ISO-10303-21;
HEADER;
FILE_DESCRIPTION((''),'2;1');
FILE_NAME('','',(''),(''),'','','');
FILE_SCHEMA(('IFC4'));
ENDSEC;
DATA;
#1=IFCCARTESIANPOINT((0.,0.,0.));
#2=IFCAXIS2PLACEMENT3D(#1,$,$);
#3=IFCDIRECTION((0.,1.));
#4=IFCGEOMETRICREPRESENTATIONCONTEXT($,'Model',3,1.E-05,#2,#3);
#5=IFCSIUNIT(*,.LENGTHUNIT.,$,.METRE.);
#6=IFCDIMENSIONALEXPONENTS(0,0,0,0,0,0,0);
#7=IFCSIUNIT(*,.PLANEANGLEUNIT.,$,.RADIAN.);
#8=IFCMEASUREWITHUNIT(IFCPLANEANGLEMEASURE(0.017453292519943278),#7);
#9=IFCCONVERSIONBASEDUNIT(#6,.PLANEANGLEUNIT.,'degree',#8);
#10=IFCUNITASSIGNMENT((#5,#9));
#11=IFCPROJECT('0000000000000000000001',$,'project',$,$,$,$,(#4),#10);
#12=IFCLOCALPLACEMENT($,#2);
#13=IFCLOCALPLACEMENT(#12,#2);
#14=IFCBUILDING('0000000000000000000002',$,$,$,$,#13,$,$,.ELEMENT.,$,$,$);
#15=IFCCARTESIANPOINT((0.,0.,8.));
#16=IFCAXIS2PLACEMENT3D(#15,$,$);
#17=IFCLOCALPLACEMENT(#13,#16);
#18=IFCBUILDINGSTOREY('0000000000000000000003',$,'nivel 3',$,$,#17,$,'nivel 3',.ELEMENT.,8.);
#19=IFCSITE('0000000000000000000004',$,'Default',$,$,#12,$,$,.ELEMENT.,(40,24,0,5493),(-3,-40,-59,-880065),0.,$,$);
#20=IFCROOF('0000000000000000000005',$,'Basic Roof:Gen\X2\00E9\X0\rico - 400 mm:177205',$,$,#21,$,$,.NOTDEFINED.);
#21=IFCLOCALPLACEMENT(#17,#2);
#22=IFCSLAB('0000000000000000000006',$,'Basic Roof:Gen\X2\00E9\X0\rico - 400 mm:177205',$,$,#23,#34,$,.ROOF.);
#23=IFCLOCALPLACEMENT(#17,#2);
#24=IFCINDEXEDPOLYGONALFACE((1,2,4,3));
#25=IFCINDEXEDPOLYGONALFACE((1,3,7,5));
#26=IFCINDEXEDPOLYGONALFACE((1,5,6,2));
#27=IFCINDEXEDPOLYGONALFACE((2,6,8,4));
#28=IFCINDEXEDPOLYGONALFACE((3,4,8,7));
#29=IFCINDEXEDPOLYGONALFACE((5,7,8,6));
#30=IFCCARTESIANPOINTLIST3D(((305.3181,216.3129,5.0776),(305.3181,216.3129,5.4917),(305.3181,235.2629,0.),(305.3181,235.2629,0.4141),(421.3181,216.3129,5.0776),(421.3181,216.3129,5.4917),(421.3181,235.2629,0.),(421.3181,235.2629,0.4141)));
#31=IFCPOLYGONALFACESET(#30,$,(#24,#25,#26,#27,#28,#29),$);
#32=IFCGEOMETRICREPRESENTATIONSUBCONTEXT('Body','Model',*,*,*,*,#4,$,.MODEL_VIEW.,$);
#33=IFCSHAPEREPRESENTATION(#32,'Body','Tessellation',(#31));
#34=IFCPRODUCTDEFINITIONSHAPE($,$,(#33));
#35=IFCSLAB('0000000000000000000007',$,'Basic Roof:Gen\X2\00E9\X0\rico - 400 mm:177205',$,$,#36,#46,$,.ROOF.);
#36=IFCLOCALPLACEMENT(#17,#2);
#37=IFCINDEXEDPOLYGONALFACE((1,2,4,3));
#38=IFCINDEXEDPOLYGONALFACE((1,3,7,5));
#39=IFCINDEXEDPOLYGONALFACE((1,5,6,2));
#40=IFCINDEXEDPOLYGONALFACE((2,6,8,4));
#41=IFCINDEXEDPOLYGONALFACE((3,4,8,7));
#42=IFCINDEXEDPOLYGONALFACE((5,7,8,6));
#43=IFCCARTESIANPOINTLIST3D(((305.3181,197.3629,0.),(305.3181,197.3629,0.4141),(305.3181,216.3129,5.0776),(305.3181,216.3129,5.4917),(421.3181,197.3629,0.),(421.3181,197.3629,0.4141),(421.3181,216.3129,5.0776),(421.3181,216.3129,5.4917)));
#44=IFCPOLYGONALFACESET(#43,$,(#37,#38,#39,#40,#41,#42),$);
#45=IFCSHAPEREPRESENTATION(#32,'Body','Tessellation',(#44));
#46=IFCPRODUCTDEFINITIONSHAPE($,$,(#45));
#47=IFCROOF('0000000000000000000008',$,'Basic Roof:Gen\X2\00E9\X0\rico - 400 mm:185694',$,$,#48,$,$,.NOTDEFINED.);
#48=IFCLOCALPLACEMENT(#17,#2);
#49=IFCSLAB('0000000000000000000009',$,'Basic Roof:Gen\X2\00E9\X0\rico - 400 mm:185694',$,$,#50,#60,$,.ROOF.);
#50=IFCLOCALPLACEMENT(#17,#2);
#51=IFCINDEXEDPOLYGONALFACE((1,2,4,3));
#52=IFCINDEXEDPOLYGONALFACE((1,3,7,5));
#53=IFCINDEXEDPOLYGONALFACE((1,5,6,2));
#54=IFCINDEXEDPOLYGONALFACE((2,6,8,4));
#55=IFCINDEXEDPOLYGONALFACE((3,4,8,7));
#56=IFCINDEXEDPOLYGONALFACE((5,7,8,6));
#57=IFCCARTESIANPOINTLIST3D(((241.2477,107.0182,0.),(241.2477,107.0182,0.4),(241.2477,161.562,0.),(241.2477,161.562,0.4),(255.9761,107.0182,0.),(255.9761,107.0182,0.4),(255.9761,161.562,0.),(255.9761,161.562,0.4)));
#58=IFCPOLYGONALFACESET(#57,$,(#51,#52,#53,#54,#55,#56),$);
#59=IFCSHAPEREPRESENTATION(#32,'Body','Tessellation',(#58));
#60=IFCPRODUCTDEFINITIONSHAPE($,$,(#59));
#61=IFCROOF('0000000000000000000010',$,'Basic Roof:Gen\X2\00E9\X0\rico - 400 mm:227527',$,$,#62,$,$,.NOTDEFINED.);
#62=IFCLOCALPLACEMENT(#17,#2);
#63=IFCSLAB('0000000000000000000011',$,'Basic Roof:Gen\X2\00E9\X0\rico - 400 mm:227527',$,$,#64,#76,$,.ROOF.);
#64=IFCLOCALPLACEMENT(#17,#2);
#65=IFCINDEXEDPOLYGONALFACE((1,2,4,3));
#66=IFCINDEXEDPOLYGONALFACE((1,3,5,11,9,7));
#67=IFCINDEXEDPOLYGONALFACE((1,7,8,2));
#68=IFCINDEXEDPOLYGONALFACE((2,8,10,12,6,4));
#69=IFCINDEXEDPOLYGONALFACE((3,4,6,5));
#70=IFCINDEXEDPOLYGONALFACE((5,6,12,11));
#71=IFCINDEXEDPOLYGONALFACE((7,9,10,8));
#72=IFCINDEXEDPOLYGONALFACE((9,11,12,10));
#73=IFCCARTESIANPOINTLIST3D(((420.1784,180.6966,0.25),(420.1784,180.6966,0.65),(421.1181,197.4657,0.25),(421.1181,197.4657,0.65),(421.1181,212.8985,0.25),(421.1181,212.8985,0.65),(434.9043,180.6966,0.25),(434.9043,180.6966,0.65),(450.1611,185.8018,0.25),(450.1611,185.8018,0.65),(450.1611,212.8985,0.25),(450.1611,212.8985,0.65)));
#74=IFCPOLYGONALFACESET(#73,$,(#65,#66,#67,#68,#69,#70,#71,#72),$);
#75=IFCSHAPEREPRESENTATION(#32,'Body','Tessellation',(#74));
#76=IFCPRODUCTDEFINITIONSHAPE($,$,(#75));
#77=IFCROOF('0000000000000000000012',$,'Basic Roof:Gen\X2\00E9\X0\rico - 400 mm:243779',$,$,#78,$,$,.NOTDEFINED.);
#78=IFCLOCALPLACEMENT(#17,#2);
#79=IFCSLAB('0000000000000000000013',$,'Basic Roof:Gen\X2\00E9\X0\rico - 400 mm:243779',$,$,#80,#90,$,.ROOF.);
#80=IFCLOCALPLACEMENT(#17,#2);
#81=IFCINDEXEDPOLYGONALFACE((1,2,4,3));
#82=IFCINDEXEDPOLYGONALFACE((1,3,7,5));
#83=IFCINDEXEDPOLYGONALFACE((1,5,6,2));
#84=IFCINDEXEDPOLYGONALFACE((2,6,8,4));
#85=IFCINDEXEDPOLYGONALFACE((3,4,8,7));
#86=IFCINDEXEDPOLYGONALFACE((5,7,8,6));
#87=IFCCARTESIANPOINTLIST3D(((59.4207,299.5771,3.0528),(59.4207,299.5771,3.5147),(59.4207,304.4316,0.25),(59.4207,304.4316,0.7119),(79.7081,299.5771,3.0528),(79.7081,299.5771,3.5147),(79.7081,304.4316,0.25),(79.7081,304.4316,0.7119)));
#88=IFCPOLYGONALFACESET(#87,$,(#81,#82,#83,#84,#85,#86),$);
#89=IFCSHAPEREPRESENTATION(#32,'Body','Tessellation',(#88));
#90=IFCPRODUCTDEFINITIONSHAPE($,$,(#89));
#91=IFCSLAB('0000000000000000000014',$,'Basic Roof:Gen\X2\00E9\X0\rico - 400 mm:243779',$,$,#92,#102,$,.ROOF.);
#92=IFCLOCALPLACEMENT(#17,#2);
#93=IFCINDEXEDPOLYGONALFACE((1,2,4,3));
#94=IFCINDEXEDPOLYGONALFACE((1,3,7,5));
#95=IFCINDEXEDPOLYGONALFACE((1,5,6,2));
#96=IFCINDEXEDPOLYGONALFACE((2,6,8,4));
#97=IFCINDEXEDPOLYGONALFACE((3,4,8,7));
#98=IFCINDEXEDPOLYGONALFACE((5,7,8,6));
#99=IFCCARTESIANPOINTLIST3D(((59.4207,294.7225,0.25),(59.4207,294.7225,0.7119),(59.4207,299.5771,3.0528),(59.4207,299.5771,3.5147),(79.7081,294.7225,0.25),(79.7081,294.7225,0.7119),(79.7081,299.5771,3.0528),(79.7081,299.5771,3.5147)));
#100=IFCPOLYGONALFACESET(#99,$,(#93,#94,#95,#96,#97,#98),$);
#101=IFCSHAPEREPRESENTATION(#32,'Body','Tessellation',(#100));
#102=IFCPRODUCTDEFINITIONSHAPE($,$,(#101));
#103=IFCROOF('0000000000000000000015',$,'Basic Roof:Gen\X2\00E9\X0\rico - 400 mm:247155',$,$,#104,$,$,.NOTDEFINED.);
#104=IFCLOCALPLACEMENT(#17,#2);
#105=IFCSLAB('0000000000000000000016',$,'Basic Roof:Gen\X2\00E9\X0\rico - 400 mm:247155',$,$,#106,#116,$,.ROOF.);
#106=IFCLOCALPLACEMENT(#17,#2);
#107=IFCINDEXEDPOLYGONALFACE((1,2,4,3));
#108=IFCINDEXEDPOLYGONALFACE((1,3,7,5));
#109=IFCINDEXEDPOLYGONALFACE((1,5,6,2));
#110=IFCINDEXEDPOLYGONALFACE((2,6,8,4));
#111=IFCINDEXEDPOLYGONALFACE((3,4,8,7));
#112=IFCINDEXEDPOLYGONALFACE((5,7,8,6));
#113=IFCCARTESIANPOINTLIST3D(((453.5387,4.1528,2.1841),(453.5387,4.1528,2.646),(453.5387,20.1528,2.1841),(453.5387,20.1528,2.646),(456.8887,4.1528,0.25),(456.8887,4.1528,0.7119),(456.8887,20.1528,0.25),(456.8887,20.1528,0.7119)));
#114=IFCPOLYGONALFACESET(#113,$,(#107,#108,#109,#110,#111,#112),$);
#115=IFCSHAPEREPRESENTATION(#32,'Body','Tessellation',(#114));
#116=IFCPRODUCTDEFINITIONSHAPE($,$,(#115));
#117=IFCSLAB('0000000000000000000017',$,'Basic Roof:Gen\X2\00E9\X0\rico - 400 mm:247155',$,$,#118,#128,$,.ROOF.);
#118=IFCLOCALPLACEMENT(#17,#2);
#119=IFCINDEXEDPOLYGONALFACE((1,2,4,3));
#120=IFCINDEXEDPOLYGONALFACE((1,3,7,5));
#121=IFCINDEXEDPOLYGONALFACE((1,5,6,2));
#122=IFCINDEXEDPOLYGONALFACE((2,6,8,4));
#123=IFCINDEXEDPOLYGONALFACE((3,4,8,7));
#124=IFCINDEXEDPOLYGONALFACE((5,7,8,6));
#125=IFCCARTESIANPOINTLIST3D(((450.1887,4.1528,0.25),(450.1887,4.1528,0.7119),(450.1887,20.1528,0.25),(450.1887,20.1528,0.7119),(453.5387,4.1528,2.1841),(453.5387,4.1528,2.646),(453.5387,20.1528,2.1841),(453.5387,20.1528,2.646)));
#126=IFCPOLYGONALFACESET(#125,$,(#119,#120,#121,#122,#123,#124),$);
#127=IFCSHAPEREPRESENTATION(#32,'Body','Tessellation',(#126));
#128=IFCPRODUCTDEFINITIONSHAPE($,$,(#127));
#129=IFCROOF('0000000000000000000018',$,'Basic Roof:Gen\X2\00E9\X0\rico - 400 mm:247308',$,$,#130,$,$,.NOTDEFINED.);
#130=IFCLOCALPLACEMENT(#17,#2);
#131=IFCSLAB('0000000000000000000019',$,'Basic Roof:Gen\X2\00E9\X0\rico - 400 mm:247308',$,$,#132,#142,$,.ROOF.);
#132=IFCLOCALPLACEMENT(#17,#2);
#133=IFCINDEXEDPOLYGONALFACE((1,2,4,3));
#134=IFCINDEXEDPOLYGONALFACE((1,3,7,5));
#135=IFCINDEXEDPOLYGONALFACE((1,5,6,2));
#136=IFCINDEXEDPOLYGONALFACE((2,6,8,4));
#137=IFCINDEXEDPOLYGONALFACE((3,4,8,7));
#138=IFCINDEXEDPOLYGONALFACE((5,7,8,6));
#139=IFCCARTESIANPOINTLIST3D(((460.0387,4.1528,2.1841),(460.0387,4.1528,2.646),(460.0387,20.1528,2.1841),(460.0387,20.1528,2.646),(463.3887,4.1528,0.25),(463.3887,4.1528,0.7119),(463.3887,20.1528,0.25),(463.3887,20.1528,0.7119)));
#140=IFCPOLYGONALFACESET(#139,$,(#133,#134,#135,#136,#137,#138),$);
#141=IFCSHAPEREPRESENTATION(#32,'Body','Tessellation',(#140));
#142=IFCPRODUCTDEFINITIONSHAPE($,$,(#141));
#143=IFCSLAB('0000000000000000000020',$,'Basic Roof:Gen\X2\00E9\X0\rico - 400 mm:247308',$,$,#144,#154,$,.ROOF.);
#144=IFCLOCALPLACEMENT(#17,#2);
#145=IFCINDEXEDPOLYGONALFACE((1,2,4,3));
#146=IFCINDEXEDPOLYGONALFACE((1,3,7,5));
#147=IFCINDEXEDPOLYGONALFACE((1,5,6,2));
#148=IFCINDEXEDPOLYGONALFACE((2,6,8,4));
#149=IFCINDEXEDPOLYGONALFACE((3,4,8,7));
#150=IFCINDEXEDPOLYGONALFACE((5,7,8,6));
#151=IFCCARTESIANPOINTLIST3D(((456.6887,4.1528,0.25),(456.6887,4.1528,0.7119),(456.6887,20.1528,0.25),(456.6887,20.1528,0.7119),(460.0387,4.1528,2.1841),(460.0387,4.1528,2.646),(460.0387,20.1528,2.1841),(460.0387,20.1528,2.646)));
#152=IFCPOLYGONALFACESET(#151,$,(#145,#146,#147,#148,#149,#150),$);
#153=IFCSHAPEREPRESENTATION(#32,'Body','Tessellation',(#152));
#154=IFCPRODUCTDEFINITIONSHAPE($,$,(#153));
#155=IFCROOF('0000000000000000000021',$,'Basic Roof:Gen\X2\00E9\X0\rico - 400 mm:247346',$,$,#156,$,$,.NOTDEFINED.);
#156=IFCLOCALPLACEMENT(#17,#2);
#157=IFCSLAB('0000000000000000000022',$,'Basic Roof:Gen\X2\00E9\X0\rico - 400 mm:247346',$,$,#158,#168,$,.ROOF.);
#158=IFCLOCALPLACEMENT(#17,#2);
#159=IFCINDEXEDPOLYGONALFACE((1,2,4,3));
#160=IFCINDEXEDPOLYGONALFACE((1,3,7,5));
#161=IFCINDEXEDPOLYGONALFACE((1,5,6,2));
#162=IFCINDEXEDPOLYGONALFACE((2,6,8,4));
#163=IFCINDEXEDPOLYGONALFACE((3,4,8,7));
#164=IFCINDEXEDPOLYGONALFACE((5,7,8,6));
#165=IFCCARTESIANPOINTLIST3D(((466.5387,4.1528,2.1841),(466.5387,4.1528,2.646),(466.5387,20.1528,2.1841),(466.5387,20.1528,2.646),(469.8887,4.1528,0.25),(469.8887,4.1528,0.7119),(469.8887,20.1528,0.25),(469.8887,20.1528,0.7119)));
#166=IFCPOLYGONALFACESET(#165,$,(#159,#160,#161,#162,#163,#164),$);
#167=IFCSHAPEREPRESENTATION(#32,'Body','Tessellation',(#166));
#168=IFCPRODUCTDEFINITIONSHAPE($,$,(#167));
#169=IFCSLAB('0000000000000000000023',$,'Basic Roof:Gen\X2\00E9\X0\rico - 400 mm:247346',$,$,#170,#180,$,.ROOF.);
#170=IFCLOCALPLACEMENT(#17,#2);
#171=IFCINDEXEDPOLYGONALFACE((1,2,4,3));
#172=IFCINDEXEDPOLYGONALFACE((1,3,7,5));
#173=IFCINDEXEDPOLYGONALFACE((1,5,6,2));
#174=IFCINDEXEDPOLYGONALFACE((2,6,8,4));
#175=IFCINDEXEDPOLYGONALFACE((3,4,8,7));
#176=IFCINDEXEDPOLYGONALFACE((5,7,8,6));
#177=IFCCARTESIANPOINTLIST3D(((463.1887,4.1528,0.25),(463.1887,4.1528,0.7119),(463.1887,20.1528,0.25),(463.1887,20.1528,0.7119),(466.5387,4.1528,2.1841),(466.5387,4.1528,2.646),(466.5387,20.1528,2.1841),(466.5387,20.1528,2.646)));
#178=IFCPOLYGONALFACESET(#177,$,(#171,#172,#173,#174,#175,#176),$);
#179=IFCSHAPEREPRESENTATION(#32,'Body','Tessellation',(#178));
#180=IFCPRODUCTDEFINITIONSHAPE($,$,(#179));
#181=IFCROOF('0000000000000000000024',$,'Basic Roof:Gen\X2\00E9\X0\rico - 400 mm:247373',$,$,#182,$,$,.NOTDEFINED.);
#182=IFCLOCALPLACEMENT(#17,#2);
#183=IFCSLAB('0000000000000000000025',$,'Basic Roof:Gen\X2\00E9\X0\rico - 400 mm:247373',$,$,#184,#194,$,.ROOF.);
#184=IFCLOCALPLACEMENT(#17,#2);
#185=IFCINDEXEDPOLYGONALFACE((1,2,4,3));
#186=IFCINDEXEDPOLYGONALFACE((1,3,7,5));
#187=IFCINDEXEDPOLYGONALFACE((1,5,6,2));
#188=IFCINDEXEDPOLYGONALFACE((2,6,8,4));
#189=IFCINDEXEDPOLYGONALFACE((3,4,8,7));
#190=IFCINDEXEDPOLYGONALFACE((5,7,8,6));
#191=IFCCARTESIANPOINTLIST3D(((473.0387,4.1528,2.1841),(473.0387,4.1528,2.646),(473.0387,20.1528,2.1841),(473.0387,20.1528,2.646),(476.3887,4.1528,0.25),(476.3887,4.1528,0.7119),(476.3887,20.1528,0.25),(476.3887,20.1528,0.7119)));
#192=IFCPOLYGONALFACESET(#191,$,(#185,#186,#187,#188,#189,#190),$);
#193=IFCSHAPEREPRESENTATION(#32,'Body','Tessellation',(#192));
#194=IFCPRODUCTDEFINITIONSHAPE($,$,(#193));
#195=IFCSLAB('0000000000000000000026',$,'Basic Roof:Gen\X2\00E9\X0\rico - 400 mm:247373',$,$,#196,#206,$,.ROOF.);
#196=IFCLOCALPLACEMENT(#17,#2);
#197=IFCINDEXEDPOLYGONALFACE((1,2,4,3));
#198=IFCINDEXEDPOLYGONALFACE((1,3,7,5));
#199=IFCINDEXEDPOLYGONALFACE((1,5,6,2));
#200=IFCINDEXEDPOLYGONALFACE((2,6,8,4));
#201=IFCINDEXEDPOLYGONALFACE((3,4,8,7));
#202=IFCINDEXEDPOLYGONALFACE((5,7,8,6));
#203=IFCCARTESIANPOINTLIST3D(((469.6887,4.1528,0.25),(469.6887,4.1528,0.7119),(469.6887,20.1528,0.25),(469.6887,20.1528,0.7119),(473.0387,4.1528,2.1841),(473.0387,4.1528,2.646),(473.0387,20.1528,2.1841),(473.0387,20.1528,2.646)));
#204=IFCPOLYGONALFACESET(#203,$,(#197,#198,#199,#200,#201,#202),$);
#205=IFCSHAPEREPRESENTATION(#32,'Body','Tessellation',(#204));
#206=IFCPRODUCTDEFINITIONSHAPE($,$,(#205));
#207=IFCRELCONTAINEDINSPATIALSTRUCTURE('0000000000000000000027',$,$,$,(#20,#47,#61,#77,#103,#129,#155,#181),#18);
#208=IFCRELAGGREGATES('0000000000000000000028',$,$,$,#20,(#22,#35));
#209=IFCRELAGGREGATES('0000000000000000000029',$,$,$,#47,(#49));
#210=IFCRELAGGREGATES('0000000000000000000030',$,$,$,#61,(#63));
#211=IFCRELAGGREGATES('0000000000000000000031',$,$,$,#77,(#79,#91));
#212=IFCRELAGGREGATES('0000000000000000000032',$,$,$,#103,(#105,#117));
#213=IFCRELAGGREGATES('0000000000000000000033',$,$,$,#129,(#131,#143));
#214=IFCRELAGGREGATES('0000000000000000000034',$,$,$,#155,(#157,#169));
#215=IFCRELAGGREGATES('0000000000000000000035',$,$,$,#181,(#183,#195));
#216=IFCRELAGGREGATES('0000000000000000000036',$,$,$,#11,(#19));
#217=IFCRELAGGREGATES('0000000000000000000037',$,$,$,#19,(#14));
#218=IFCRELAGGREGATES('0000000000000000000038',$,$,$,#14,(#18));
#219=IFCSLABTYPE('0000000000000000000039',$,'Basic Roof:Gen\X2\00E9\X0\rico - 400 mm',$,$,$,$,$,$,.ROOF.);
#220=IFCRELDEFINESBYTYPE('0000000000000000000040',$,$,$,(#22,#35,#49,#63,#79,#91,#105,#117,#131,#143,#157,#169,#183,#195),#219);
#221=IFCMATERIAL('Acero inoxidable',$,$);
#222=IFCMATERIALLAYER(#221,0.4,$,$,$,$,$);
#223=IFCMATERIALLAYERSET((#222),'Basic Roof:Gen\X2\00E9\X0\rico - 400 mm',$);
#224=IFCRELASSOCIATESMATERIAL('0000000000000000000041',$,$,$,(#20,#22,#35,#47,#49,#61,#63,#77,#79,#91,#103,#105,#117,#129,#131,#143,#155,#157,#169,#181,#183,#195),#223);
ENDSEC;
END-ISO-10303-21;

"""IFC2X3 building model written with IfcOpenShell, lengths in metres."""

from ifc_helpers import new_model, entity, si_unit, converted_unit, direction, frame, frame_2d, origin, origin_2d_with_axis, place, context, subcontext, project, spatial, polyline, rectangle, outline, extrude, material, layer, layer_set, type_object, element, aggregate, save


model = new_model("IFC2X3")

# Units and contexts
model_context = context("Model", 3, precision=1e-05, world=origin(), true_north=direction((0.0, 1.0)))
body_context = subcontext(model_context, "Body", "Model", "MODEL_VIEW")
ifc_project = project(units=[si_unit("LENGTHUNIT", "METRE"), converted_unit("PLANEANGLEUNIT", "degree", entity("IfcPlaneAngleMeasure", 0.017453292519943278), si_unit("PLANEANGLEUNIT", "RADIAN"), dimensions=[0, 0, 0, 0, 0, 0, 0])], contexts=[model_context])

# Site, building, storey
site_placement = place(None, origin())
site = spatial("IfcSite", under=ifc_project, at=site_placement, Name="Default", CompositionType="ELEMENT", RefLatitude=(40, 24, 0, 5493), RefLongitude=(-3, -40, -59, -880065), RefElevation=0.0)
building_placement = place(site_placement, origin())
building = spatial("IfcBuilding", under=site, at=building_placement, CompositionType="ELEMENT")
storey_placement = place(building_placement, frame((0.0, 0.0, 8.0)))
storey = spatial("IfcBuildingStorey", under=building, at=storey_placement, Name="nivel 3", LongName="nivel 3", CompositionType="ELEMENT", Elevation=8.0)

# Roof, slabs
ifc_material = material(Name="Acero inoxidable")
ifc_layer = layer(ifc_material, 0.4)
ifc_layer_set = layer_set([ifc_layer], Name="Basic Roof:Genérico - 400 mm")
slab_type = type_object("IfcSlabType", Name="Basic Roof:Genérico - 400 mm", PredefinedType="ROOF")
roof_1_placement = place(storey_placement, frame((305.3181, 197.3629, 0.0)))
roof_1 = element("IfcRoof", 1, at=roof_1_placement, inside=storey, material=ifc_layer_set, Name="Basic Roof:Genérico - 400 mm:177205", ShapeType="NOTDEFINED")
slab_1_placement = place(roof_1_placement, origin())
slab_1 = element("IfcSlab", 2, at=slab_1_placement, type_object=slab_type, material=ifc_layer_set, Name="Basic Roof:Genérico - 400 mm:177205", PredefinedType="ROOF", context=body_context, shape_type="SweptSolid", body=[
    extrude(rectangle(XDim=116.0, YDim=19.6185, at=origin_2d_with_axis()), frame((58.0, 28.425, 2.5388), z_axis=(0.0, 0.258819, 0.965926), x_axis=(1.0, 0.0, 0.0)), (0.0, -0.258819, 0.965926), 0.4141),
])
slab_2_placement = place(roof_1_placement, origin())
slab_2 = element("IfcSlab", 3, at=slab_2_placement, type_object=slab_type, material=ifc_layer_set, Name="Basic Roof:Genérico - 400 mm:177205", PredefinedType="ROOF", context=body_context, shape_type="SweptSolid", body=[
    extrude(rectangle(XDim=19.6185, YDim=116.0, at=frame_2d((0.0, 0.0), x_axis=(0.0, 1.0))), frame((58.0, 9.475, 2.5388), z_axis=(0.0, -0.258819, 0.965926), x_axis=(1.0, 0.0, 0.0)), (0.0, 0.258819, 0.965926), 0.4141),
])
aggregate(roof_1, [slab_1, slab_2])

# Roofs, slabs
roof_2_placement = place(storey_placement, frame((241.2477, 107.0182, 0.0)))
roof_2 = element("IfcRoof", 4, at=roof_2_placement, inside=storey, material=ifc_layer_set, Name="Basic Roof:Genérico - 400 mm:185694", ShapeType="NOTDEFINED")
slab_3_placement = place(roof_2_placement, origin())
slab_3 = element("IfcSlab", 5, at=slab_3_placement, type_object=slab_type, material=ifc_layer_set, Name="Basic Roof:Genérico - 400 mm:185694", PredefinedType="ROOF", context=body_context, shape_type="SweptSolid", body=[
    extrude(rectangle(XDim=54.5438, YDim=14.7284, at=frame_2d((0.0, 0.0), x_axis=(0.0, 1.0))), frame((7.3642, 27.2719, 0.0)), (0.0, 0.0, 1.0), 0.4),
])
aggregate(roof_2, [slab_3])
roof_3_placement = place(storey_placement, frame((420.1784, 180.6966, 0.25)))
roof_3 = element("IfcRoof", 6, at=roof_3_placement, inside=storey, material=ifc_layer_set, Name="Basic Roof:Genérico - 400 mm:227527", ShapeType="NOTDEFINED")
slab_4_placement = place(roof_3_placement, origin())
slab_4 = element("IfcSlab", 7, at=slab_4_placement, type_object=slab_type, material=ifc_layer_set, Name="Basic Roof:Genérico - 400 mm:227527", PredefinedType="ROOF", context=body_context, shape_type="SweptSolid", body=[
    extrude(outline(polyline([(-14.9913, -16.101), (-0.2655, -16.101), (14.9913, -10.9957), (14.9913, 16.101), (-14.0517, 16.101), (-14.0517, 0.6682), (-14.9913, -16.101)])), frame((14.9913, 16.101, 0.0)), (0.0, 0.0, 1.0), 0.4),
])
aggregate(roof_3, [slab_4])

# Roofs, slabs
roof_4_placement = place(storey_placement, frame((59.4207, 294.7225, 0.25)))
roof_4 = element("IfcRoof", 8, at=roof_4_placement, inside=storey, material=ifc_layer_set, Name="Basic Roof:Genérico - 400 mm:243779", ShapeType="NOTDEFINED")
slab_5_placement = place(roof_4_placement, origin())
slab_5 = element("IfcSlab", 9, at=slab_5_placement, type_object=slab_type, material=ifc_layer_set, Name="Basic Roof:Genérico - 400 mm:243779", PredefinedType="ROOF", context=body_context, shape_type="SweptSolid", body=[
    extrude(rectangle(XDim=20.2874, YDim=5.6056, at=frame_2d((0.0, 0.0), x_axis=(1.0, 0.0))), frame((10.1437, 7.2818, 1.4014), z_axis=(0.0, 0.5, 0.866025), x_axis=(1.0, 0.0, 0.0)), (0.0, -0.5, 0.866025), 0.4619),
])
slab_6_placement = place(roof_4_placement, origin())
slab_6 = element("IfcSlab", 10, at=slab_6_placement, type_object=slab_type, material=ifc_layer_set, Name="Basic Roof:Genérico - 400 mm:243779", PredefinedType="ROOF", context=body_context, shape_type="SweptSolid", body=[
    extrude(rectangle(XDim=5.6056, YDim=20.2874, at=frame_2d((0.0, 0.0), x_axis=(0.0, 1.0))), frame((10.1437, 2.4273, 1.4014), z_axis=(0.0, -0.5, 0.866025), x_axis=(1.0, 0.0, 0.0)), (0.0, 0.5, 0.866025), 0.4619),
])
aggregate(roof_4, [slab_5, slab_6])
roof_5_placement = place(storey_placement, frame((450.1887, 4.1528, 0.25)))
roof_5 = element("IfcRoof", 11, at=roof_5_placement, inside=storey, material=ifc_layer_set, Name="Basic Roof:Genérico - 400 mm:247155", ShapeType="NOTDEFINED")
slab_7_placement = place(roof_5_placement, origin())
slab_7 = element("IfcSlab", 12, at=slab_7_placement, type_object=slab_type, material=ifc_layer_set, Name="Basic Roof:Genérico - 400 mm:247155", PredefinedType="ROOF", context=body_context, shape_type="SweptSolid", body=[
    extrude(rectangle(XDim=3.8682, YDim=16.0, at=frame_2d((0.0, 0.0), x_axis=(1.0, 0.0))), frame((5.025, 8.0, 0.9671), z_axis=(0.5, 0.0, 0.866025), x_axis=(0.866025, 0.0, -0.5)), (-0.5, 0.0, 0.866025), 0.4619),
])
slab_8_placement = place(roof_5_placement, origin())
slab_8 = element("IfcSlab", 13, at=slab_8_placement, type_object=slab_type, material=ifc_layer_set, Name="Basic Roof:Genérico - 400 mm:247155", PredefinedType="ROOF", context=body_context, shape_type="SweptSolid", body=[
    extrude(rectangle(XDim=16.0, YDim=3.8682, at=frame_2d((0.0, 0.0), x_axis=(0.0, 1.0))), frame((1.675, 8.0, 0.9671), z_axis=(-0.5, 0.0, 0.866025), x_axis=(0.866025, 0.0, 0.5)), (0.5, 0.0, 0.866025), 0.4619),
])
aggregate(roof_5, [slab_7, slab_8])
roof_6_placement = place(storey_placement, frame((456.6887, 4.1528, 0.25)))
roof_6 = element("IfcRoof", 14, at=roof_6_placement, inside=storey, material=ifc_layer_set, Name="Basic Roof:Genérico - 400 mm:247308", ShapeType="NOTDEFINED")
slab_9_placement = place(roof_6_placement, origin())
slab_9 = element("IfcSlab", 15, at=slab_9_placement, type_object=slab_type, material=ifc_layer_set, Name="Basic Roof:Genérico - 400 mm:247308", PredefinedType="ROOF", context=body_context, shape_type="SweptSolid", body=[
    extrude(rectangle(XDim=3.8682, YDim=16.0, at=frame_2d((0.0, 0.0), x_axis=(1.0, 0.0))), frame((5.025, 8.0, 0.9671), z_axis=(0.5, 0.0, 0.866025), x_axis=(0.866025, 0.0, -0.5)), (-0.5, 0.0, 0.866025), 0.4619),
])
slab_10_placement = place(roof_6_placement, origin())
slab_10 = element("IfcSlab", 16, at=slab_10_placement, type_object=slab_type, material=ifc_layer_set, Name="Basic Roof:Genérico - 400 mm:247308", PredefinedType="ROOF", context=body_context, shape_type="SweptSolid", body=[
    extrude(rectangle(XDim=16.0, YDim=3.8682, at=frame_2d((0.0, 0.0), x_axis=(0.0, 1.0))), frame((1.675, 8.0, 0.9671), z_axis=(-0.5, 0.0, 0.866025), x_axis=(0.866025, 0.0, 0.5)), (0.5, 0.0, 0.866025), 0.4619),
])
aggregate(roof_6, [slab_9, slab_10])
roof_7_placement = place(storey_placement, frame((463.1887, 4.1528, 0.25)))
roof_7 = element("IfcRoof", 17, at=roof_7_placement, inside=storey, material=ifc_layer_set, Name="Basic Roof:Genérico - 400 mm:247346", ShapeType="NOTDEFINED")
slab_11_placement = place(roof_7_placement, origin())
slab_11 = element("IfcSlab", 18, at=slab_11_placement, type_object=slab_type, material=ifc_layer_set, Name="Basic Roof:Genérico - 400 mm:247346", PredefinedType="ROOF", context=body_context, shape_type="SweptSolid", body=[
    extrude(rectangle(XDim=3.8682, YDim=16.0, at=frame_2d((0.0, 0.0), x_axis=(1.0, 0.0))), frame((5.025, 8.0, 0.9671), z_axis=(0.5, 0.0, 0.866025), x_axis=(0.866025, 0.0, -0.5)), (-0.5, 0.0, 0.866025), 0.4619),
])
slab_12_placement = place(roof_7_placement, origin())
slab_12 = element("IfcSlab", 19, at=slab_12_placement, type_object=slab_type, material=ifc_layer_set, Name="Basic Roof:Genérico - 400 mm:247346", PredefinedType="ROOF", context=body_context, shape_type="SweptSolid", body=[
    extrude(rectangle(XDim=16.0, YDim=3.8682, at=frame_2d((0.0, 0.0), x_axis=(0.0, 1.0))), frame((1.675, 8.0, 0.9671), z_axis=(-0.5, 0.0, 0.866025), x_axis=(0.866025, 0.0, 0.5)), (0.5, 0.0, 0.866025), 0.4619),
])
aggregate(roof_7, [slab_11, slab_12])
roof_8_placement = place(storey_placement, frame((469.6887, 4.1528, 0.25)))
roof_8 = element("IfcRoof", 20, at=roof_8_placement, inside=storey, material=ifc_layer_set, Name="Basic Roof:Genérico - 400 mm:247373", ShapeType="NOTDEFINED")
slab_13_placement = place(roof_8_placement, origin())
slab_13 = element("IfcSlab", 21, at=slab_13_placement, type_object=slab_type, material=ifc_layer_set, Name="Basic Roof:Genérico - 400 mm:247373", PredefinedType="ROOF", context=body_context, shape_type="SweptSolid", body=[
    extrude(rectangle(XDim=3.8682, YDim=16.0, at=frame_2d((0.0, 0.0), x_axis=(1.0, 0.0))), frame((5.025, 8.0, 0.9671), z_axis=(0.5, 0.0, 0.866025), x_axis=(0.866025, 0.0, -0.5)), (-0.5, 0.0, 0.866025), 0.4619),
])
slab_14_placement = place(roof_8_placement, origin())
slab_14 = element("IfcSlab", 22, at=slab_14_placement, type_object=slab_type, material=ifc_layer_set, Name="Basic Roof:Genérico - 400 mm:247373", PredefinedType="ROOF", context=body_context, shape_type="SweptSolid", body=[
    extrude(rectangle(XDim=16.0, YDim=3.8682, at=frame_2d((0.0, 0.0), x_axis=(0.0, 1.0))), frame((1.675, 8.0, 0.9671), z_axis=(-0.5, 0.0, 0.866025), x_axis=(0.866025, 0.0, 0.5)), (0.5, 0.0, 0.866025), 0.4619),
])
aggregate(roof_8, [slab_13, slab_14])

save(model, "model.ifc")
